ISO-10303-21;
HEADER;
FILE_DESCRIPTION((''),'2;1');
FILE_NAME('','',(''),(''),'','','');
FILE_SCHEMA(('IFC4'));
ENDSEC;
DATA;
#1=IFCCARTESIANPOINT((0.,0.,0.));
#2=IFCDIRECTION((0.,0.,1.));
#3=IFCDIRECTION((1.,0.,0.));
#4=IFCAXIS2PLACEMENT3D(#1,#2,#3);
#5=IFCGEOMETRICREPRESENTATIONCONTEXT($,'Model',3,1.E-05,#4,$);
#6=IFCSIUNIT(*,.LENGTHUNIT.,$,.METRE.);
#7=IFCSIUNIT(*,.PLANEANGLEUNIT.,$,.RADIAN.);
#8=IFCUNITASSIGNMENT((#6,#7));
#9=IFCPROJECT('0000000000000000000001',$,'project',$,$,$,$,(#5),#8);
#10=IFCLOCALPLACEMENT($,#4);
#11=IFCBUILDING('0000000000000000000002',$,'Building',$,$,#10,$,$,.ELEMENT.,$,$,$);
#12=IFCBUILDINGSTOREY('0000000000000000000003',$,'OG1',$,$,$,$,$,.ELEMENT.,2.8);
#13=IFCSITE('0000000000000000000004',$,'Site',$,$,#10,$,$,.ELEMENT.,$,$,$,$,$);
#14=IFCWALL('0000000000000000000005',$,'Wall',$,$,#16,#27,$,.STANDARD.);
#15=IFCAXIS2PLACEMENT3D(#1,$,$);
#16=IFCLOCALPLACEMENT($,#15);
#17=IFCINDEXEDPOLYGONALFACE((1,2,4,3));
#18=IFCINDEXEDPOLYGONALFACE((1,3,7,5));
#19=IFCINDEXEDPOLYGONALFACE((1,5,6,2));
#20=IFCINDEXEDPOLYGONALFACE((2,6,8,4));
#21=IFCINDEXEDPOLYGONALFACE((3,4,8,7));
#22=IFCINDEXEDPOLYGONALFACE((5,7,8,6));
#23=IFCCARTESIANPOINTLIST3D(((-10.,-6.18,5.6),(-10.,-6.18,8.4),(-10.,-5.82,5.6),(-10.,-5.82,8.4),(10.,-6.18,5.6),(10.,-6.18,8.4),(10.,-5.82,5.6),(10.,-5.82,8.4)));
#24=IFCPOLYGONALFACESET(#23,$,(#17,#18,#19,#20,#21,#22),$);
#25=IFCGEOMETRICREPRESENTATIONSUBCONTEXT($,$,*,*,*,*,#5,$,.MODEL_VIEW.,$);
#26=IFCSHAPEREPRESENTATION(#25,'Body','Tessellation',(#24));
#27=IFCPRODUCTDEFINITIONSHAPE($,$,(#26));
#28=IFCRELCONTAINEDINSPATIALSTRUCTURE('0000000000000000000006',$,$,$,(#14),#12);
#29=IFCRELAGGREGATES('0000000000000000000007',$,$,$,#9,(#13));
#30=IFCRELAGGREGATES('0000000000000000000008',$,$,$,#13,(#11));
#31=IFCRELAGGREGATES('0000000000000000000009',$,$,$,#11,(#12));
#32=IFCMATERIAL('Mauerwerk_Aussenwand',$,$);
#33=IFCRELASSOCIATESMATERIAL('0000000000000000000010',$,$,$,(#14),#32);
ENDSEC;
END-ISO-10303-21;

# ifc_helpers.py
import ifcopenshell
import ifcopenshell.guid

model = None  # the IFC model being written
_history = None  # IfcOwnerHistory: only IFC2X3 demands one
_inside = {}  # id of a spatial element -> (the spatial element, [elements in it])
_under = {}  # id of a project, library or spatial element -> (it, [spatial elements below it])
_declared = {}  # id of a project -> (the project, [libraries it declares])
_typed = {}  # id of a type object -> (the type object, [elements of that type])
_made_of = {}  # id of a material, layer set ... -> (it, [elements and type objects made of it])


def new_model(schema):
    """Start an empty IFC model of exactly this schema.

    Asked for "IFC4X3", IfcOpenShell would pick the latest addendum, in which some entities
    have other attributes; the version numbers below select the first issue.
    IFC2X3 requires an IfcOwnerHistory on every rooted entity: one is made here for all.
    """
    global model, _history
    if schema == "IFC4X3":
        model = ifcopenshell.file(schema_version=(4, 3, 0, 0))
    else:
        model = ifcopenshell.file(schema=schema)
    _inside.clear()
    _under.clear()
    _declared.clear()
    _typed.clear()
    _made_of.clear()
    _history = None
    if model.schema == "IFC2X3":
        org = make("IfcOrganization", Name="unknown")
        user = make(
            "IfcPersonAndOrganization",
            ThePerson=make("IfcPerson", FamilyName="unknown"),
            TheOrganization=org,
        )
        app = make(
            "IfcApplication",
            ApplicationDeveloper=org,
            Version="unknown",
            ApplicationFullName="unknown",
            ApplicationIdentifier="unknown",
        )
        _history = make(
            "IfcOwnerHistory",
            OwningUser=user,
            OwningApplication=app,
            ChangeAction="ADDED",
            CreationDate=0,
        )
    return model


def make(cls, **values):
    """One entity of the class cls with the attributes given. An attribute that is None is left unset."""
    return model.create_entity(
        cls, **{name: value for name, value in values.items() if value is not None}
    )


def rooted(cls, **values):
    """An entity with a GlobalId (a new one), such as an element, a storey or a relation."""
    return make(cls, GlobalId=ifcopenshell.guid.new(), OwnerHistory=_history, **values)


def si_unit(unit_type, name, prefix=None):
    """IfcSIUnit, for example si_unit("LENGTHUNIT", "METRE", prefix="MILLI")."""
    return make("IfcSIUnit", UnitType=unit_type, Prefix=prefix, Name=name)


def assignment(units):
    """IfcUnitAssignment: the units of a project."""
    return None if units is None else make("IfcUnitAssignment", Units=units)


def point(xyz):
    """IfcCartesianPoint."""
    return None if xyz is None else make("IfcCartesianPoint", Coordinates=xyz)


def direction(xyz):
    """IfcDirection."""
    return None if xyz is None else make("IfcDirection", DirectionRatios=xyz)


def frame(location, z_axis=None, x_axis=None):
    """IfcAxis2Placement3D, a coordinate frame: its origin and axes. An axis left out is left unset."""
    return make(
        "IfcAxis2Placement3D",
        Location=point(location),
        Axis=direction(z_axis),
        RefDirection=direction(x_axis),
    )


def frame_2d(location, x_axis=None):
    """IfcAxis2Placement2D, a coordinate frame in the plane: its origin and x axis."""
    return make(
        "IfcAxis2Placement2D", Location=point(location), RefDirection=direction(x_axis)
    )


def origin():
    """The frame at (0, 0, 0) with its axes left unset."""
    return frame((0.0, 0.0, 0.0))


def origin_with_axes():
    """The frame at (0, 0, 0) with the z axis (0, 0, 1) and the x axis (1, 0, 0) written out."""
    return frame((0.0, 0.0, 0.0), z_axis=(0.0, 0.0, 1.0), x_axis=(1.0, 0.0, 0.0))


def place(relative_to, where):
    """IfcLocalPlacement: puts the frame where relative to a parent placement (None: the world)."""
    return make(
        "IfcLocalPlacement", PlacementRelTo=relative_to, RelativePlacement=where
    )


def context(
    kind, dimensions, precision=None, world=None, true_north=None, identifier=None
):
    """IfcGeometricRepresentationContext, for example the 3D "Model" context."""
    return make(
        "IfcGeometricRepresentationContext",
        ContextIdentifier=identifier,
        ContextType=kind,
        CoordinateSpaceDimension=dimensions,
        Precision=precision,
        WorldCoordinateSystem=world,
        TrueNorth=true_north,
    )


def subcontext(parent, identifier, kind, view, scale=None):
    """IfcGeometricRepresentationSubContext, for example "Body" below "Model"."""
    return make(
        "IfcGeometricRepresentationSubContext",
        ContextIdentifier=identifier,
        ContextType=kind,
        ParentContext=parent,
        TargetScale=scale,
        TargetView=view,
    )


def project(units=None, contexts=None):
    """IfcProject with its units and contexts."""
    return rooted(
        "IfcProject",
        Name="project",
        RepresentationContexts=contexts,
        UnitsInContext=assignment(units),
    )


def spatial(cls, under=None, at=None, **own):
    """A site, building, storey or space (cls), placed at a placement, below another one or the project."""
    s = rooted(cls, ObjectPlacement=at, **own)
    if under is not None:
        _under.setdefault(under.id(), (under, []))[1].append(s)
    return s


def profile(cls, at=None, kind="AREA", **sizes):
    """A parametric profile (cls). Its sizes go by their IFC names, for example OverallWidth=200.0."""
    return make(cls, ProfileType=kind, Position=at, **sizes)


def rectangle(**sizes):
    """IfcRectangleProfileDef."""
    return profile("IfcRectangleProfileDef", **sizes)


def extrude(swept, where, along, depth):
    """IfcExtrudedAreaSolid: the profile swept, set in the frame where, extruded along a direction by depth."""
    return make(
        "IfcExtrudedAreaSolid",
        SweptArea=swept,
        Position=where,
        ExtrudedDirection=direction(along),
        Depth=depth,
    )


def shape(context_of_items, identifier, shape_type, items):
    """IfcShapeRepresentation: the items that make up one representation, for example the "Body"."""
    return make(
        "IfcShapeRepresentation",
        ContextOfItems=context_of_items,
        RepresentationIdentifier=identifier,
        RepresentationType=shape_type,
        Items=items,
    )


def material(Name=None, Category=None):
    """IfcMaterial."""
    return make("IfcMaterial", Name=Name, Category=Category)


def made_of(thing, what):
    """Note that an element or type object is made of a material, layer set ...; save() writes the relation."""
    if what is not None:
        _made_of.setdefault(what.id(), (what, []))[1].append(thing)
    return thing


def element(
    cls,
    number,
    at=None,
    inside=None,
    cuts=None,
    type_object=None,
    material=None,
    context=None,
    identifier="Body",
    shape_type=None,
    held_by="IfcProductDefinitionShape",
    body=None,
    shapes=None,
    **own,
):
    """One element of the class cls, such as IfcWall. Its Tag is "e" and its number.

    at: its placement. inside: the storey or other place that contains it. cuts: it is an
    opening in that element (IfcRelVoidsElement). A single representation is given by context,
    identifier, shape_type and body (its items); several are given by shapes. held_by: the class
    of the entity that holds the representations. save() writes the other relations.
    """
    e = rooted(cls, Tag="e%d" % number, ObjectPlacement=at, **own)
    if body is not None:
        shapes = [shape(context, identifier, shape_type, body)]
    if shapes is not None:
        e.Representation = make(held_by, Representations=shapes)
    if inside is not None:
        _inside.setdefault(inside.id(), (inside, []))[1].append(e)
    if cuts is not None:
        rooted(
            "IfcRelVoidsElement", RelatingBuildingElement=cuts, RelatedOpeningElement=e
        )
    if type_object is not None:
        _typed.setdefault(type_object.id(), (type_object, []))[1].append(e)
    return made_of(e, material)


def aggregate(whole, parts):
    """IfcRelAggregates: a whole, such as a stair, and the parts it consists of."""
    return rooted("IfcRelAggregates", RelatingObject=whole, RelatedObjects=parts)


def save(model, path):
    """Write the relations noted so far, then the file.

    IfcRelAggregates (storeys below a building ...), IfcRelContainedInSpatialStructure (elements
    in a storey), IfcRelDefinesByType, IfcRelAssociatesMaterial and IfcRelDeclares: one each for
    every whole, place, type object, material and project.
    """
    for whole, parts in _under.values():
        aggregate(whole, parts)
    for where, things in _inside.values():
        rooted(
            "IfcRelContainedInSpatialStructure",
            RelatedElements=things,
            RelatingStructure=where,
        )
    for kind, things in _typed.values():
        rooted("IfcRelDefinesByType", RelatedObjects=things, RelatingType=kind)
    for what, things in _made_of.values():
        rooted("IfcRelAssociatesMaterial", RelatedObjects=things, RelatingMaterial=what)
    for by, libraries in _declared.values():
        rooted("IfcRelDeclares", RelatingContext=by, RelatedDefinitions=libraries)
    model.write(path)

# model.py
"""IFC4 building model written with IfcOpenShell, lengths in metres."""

from ifc_helpers import new_model, si_unit, frame, frame_2d, origin, origin_with_axes, place, context, subcontext, project, spatial, rectangle, extrude, material, element, save


model = new_model("IFC4")

# Units and contexts
model_context = context("Model", 3, precision=1e-05, world=origin_with_axes())
sub_context = subcontext(model_context, None, None, "MODEL_VIEW")
ifc_project = project(units=[si_unit("LENGTHUNIT", "METRE"), si_unit("PLANEANGLEUNIT", "RADIAN")], contexts=[model_context])

# Site, building, storey
placement_1 = place(None, origin_with_axes())
site = spatial("IfcSite", under=ifc_project, at=placement_1, Name="Site", CompositionType="ELEMENT")
building = spatial("IfcBuilding", under=site, at=placement_1, Name="Building", CompositionType="ELEMENT")
storey = spatial("IfcBuildingStorey", under=building, Name="OG1", CompositionType="ELEMENT", Elevation=2.8)

# Wall
ifc_material = material(Name="Mauerwerk_Aussenwand")
placement_2 = place(None, origin_with_axes())
placement_3 = place(placement_2, frame((0.0, 0.0, 2.8)))
wall_placement = place(placement_3, frame((-10.0, -6.0, 2.8), x_axis=(1.0, 0.0, 0.0)))
element("IfcWall", 1, at=wall_placement, inside=storey, material=ifc_material, Name="Wall", PredefinedType="STANDARD", context=sub_context, shape_type="SweptSolid", body=[
    extrude(rectangle(XDim=20.0, YDim=0.36, at=frame_2d((10.0, 0.0))), origin(), (0.0, 0.0, 1.0), 2.8),
])

save(model, "model.ifc")
